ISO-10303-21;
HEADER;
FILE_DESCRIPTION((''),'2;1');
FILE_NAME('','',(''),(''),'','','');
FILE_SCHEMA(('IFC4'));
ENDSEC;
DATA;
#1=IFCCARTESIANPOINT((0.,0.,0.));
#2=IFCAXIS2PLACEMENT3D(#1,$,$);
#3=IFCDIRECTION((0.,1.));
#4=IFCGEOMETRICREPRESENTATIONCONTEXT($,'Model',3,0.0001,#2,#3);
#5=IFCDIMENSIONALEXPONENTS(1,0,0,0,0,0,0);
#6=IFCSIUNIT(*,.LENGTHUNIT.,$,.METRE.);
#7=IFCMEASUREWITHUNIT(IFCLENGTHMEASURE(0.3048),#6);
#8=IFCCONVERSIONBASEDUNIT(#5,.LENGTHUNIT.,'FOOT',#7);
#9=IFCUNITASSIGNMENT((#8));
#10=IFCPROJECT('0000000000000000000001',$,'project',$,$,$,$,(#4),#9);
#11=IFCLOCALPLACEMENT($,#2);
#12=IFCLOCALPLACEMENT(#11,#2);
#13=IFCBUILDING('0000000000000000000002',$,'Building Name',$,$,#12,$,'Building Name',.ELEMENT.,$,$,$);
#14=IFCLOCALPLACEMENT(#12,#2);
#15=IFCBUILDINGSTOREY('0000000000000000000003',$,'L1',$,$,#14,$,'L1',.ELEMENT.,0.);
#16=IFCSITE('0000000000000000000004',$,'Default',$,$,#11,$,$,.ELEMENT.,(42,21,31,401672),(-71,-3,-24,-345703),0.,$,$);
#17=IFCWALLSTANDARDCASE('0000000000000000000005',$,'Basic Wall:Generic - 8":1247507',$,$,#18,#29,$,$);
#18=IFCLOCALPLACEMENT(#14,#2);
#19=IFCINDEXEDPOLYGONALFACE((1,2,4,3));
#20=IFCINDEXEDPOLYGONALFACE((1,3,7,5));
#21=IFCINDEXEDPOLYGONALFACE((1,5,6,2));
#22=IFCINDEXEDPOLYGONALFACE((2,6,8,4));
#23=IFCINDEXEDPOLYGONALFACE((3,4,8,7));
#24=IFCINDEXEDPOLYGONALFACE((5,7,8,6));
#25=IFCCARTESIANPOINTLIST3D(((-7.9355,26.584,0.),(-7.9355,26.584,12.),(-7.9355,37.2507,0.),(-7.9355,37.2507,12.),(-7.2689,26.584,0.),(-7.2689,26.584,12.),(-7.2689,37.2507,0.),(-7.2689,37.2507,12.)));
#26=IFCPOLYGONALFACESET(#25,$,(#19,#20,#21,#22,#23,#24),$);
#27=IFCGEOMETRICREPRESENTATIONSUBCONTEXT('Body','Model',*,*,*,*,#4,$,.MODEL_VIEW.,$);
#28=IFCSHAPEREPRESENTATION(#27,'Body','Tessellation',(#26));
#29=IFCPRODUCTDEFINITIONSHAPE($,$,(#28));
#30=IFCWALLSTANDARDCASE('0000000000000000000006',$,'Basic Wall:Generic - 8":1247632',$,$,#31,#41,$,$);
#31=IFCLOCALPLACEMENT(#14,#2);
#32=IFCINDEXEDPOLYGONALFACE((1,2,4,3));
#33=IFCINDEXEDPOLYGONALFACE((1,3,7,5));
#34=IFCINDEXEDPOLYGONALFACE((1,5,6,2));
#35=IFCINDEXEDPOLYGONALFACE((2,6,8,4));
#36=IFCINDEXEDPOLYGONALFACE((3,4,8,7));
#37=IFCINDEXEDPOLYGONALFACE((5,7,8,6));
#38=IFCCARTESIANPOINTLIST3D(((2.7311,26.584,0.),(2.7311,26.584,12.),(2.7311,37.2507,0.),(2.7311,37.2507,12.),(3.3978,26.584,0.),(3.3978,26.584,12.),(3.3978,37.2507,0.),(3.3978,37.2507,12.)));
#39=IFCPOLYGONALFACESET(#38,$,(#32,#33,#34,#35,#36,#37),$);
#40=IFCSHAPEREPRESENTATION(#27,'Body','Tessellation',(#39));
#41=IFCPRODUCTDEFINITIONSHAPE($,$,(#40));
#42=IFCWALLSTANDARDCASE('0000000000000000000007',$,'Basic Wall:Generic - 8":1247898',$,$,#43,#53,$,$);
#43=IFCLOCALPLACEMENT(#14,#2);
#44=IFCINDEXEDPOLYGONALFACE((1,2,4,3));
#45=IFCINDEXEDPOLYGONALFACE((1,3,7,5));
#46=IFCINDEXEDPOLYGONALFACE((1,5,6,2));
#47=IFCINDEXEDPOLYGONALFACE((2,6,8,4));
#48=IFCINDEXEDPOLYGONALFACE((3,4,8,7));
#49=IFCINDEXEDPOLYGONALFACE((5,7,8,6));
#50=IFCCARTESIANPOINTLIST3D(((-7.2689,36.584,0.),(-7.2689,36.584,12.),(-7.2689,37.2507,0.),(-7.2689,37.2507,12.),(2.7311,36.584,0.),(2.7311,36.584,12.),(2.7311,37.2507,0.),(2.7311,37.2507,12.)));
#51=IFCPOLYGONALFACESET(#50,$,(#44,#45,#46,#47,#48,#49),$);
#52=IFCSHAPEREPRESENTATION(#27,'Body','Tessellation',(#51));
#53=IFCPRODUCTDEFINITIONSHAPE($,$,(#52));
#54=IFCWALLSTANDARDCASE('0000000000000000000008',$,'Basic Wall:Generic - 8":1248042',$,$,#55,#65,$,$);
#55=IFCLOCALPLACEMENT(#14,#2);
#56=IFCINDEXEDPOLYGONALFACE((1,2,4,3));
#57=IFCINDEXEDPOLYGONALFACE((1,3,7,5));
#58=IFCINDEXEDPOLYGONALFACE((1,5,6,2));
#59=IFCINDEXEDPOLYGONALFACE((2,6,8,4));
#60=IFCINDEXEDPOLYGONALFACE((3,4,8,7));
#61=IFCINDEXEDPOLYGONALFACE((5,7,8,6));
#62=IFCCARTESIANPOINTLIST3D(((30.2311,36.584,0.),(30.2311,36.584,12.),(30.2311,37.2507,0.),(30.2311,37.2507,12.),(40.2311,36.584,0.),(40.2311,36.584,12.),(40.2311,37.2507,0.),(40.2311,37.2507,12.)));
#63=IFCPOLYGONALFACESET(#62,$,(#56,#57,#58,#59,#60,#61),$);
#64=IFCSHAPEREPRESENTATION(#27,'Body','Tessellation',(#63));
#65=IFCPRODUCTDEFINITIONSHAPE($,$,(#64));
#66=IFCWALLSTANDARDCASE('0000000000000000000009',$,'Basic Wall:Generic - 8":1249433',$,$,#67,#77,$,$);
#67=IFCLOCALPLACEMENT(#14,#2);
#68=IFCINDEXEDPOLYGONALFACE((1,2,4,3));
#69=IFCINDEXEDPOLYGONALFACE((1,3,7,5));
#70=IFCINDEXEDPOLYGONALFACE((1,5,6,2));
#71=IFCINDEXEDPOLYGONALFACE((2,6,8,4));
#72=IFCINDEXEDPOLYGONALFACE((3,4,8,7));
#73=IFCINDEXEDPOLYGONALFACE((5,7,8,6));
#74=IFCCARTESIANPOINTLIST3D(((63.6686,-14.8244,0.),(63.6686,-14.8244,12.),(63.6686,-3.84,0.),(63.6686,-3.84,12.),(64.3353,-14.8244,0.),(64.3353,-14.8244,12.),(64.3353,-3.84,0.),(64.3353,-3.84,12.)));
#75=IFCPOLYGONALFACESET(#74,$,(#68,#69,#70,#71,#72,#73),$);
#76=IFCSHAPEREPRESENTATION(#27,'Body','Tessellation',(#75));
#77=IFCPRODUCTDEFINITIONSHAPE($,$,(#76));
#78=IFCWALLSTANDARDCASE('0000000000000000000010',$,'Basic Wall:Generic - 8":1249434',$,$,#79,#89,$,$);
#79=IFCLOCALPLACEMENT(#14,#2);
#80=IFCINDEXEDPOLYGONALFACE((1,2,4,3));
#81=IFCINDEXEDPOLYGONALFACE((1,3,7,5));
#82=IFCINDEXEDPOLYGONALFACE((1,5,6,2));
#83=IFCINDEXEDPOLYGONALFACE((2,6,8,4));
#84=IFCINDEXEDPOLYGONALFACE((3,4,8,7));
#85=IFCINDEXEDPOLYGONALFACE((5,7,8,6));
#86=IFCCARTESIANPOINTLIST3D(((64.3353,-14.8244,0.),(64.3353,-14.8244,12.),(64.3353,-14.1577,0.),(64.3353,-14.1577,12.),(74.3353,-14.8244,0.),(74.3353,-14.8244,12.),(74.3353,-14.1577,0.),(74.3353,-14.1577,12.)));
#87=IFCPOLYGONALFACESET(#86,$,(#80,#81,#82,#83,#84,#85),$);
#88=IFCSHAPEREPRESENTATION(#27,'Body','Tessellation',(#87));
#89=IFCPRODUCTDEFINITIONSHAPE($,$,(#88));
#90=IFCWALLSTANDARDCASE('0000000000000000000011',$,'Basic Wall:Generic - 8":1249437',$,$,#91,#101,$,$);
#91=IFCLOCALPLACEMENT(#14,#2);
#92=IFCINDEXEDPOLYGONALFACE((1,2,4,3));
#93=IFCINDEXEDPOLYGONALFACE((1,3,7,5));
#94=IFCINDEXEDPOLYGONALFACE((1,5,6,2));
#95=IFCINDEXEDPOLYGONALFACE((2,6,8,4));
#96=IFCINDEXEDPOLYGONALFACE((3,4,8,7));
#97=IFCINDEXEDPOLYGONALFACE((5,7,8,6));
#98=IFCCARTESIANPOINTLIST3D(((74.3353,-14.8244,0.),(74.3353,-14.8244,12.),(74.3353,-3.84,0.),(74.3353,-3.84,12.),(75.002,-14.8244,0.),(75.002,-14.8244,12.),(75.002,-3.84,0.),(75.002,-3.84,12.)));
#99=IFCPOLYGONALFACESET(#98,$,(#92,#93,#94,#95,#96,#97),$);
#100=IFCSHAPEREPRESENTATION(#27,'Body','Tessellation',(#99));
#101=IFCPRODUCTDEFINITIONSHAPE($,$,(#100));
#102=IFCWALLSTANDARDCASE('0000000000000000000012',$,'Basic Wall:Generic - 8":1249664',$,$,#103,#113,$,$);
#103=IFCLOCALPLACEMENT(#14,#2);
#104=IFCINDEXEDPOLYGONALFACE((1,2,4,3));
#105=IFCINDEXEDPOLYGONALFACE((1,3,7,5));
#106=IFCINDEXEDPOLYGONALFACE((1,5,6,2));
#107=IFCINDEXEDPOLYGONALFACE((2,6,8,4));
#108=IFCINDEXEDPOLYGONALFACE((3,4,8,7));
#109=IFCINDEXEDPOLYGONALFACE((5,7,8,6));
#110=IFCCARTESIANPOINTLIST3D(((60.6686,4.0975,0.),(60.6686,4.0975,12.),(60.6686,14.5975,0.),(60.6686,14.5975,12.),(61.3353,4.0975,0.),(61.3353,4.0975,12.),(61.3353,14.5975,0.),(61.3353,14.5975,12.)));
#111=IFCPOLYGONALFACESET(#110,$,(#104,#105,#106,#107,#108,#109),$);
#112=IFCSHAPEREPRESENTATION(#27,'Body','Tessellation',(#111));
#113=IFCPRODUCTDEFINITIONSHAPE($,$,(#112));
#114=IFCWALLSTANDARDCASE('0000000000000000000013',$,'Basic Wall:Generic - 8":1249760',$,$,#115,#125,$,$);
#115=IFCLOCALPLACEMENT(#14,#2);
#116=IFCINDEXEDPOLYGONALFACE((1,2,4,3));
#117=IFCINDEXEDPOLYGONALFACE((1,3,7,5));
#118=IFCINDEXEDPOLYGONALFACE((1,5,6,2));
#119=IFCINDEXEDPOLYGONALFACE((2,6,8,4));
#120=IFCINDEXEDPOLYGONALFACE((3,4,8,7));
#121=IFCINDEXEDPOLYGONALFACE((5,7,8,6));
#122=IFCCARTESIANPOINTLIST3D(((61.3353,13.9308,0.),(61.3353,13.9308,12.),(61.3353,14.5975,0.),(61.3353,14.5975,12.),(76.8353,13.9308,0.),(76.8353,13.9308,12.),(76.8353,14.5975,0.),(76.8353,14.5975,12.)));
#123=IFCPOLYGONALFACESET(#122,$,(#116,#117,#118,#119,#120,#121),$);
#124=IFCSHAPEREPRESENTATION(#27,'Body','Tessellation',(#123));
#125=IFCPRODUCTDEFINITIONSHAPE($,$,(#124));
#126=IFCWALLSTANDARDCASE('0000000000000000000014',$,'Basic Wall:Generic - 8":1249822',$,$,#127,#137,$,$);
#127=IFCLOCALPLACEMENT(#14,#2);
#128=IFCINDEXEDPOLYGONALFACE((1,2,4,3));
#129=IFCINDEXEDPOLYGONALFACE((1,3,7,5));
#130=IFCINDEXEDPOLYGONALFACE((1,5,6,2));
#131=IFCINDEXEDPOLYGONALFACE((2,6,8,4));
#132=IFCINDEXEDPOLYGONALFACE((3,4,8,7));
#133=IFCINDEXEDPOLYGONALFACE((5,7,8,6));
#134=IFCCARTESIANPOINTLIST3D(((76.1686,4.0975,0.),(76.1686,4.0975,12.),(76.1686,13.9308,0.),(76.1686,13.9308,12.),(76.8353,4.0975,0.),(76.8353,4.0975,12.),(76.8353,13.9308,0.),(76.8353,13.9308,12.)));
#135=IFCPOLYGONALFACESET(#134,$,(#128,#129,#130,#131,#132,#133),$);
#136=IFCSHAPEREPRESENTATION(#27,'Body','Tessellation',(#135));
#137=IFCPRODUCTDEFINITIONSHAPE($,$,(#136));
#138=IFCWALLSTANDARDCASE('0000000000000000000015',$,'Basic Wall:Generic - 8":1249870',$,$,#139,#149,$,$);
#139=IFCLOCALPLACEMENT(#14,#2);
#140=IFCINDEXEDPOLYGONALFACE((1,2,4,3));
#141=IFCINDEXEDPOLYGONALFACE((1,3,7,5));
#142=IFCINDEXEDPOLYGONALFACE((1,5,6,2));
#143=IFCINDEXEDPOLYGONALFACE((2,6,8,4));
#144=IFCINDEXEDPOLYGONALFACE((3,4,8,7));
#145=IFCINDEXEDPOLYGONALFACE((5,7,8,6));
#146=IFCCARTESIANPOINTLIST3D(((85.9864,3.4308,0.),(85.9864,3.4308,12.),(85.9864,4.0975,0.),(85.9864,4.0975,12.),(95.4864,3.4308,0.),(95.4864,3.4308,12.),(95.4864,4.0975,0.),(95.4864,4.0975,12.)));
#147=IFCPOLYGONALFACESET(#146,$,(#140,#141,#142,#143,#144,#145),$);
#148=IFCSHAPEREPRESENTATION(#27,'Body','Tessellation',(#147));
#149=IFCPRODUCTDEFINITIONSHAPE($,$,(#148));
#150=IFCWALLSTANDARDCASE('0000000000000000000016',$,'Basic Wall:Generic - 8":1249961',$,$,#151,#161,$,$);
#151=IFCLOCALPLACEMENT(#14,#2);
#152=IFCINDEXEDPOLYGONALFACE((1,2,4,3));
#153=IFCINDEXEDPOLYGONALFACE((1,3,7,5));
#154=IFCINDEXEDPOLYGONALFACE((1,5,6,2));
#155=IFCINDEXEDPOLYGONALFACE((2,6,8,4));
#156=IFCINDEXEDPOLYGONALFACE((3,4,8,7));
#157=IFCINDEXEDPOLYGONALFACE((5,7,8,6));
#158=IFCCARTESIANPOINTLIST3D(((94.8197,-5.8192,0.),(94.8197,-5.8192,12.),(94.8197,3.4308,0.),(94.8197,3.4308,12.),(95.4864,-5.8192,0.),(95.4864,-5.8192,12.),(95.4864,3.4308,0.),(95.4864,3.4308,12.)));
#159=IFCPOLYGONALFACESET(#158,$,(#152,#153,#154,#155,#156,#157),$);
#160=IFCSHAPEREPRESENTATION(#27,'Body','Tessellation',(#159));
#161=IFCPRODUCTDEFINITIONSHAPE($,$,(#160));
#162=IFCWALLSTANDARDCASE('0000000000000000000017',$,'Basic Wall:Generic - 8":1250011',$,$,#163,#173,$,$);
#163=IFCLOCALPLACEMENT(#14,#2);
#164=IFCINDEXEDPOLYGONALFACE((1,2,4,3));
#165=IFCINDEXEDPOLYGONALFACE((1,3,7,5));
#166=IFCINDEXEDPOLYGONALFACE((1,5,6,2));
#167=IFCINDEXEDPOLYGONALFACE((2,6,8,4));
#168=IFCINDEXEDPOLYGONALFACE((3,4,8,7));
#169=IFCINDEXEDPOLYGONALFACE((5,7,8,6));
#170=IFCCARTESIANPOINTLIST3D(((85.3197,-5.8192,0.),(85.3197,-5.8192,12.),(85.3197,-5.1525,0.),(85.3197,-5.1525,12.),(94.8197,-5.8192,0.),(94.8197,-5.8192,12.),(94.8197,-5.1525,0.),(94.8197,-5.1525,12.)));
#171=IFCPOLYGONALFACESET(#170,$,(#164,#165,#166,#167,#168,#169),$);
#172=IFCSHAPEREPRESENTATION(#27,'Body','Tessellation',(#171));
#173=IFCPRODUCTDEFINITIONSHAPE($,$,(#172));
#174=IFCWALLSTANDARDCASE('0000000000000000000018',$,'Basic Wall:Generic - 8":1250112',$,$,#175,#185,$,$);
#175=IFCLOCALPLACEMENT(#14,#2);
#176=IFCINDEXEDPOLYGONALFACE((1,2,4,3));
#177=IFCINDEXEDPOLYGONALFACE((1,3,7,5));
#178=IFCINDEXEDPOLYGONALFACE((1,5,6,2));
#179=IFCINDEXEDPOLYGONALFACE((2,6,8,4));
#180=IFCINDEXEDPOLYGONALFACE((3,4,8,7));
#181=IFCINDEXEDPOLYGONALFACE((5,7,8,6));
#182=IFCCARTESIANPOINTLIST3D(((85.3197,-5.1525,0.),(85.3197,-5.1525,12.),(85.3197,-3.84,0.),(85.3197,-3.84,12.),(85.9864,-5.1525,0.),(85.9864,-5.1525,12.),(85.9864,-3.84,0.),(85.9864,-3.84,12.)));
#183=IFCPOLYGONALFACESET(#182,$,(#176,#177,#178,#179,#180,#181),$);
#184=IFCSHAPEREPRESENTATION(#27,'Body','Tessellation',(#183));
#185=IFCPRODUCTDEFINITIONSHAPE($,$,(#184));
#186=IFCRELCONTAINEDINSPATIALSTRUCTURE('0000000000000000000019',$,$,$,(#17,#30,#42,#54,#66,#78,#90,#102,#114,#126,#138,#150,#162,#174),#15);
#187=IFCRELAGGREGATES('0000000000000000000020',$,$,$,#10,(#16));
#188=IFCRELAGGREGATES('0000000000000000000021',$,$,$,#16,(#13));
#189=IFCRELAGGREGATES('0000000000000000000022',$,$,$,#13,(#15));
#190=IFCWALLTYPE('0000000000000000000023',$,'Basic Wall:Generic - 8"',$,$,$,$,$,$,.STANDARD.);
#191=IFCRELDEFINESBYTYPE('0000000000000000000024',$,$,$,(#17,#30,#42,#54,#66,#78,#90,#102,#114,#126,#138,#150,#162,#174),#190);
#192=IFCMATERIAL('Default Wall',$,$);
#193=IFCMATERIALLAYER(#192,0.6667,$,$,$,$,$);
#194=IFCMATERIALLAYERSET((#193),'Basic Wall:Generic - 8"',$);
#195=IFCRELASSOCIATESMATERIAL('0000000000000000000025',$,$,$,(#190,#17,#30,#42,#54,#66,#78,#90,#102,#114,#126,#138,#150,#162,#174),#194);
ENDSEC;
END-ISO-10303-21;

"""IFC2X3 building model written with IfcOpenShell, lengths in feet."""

from ifc_helpers import new_model, entity, si_unit, converted_unit, direction, frame, frame_2d, origin, place, context, subcontext, project, spatial, rectangle, extrude, material, layer, layer_set, layer_usage, type_object, element, save


model = new_model("IFC2X3")

# Units and contexts
model_context = context("Model", 3, precision=0.0001, world=origin(), true_north=direction((0.0, 1.0)))
body_context = subcontext(model_context, "Body", "Model", "MODEL_VIEW")
ifc_project = project(units=[converted_unit("LENGTHUNIT", "FOOT", entity("IfcLengthMeasure", 0.3048), si_unit("LENGTHUNIT", "METRE"), dimensions=[1, 0, 0, 0, 0, 0, 0])], contexts=[model_context])

# Site, building, storey
site_placement = place(None, origin())
site = spatial("IfcSite", under=ifc_project, at=site_placement, Name="Default", CompositionType="ELEMENT", RefLatitude=(42, 21, 31, 401672), RefLongitude=(-71, -3, -24, -345703), RefElevation=0.0)
building_placement = place(site_placement, origin())
building = spatial("IfcBuilding", under=site, at=building_placement, Name="Building Name", LongName="Building Name", CompositionType="ELEMENT")
storey_placement = place(building_placement, origin())
storey = spatial("IfcBuildingStorey", under=building, at=storey_placement, Name="L1", LongName="L1", CompositionType="ELEMENT", Elevation=0.0)

# Walls
ifc_material_1 = material(Name="Default Wall")
ifc_layer_1 = layer(ifc_material_1, 0.6667)
ifc_layer_set_1 = layer_set([ifc_layer_1], Name="Basic Wall:Generic - 8\"")
wall_type_1 = type_object("IfcWallType", Name="Basic Wall:Generic - 8\"", PredefinedType="STANDARD", material=ifc_layer_set_1)
ifc_layer_usage_1 = layer_usage(ifc_layer_set_1, "AXIS2", "POSITIVE", -0.3333)
wall_1_placement = place(storey_placement, frame((-7.6022, 37.2507, 0.0), z_axis=(0.0, 0.0, 1.0), x_axis=(0.0, -1.0, 0.0)))
element("IfcWallStandardCase", 1, at=wall_1_placement, inside=storey, type_object=wall_type_1, material=ifc_layer_usage_1, Name="Basic Wall:Generic - 8\":1247507", context=body_context, shape_type="SweptSolid", body=[
    extrude(rectangle(XDim=10.6667, YDim=0.6667, at=frame_2d((5.3333, 0.0), x_axis=(-1.0, 0.0))), origin(), (0.0, 0.0, 1.0), 12.0),
])
ifc_layer_usage_2 = layer_usage(ifc_layer_set_1, "AXIS2", "NEGATIVE", 0.3333)
wall_2_placement = place(storey_placement, frame((3.0645, 37.2507, 0.0), z_axis=(0.0, 0.0, 1.0), x_axis=(0.0, -1.0, 0.0)))
element("IfcWallStandardCase", 2, at=wall_2_placement, inside=storey, type_object=wall_type_1, material=ifc_layer_usage_2, Name="Basic Wall:Generic - 8\":1247632", context=body_context, shape_type="SweptSolid", body=[
    extrude(rectangle(XDim=10.6667, YDim=0.6667, at=frame_2d((5.3333, 0.0), x_axis=(-1.0, 0.0))), origin(), (0.0, 0.0, 1.0), 12.0),
])
ifc_layer_usage_3 = layer_usage(ifc_layer_set_1, "AXIS2", "NEGATIVE", 0.3333)
wall_3_placement = place(storey_placement, frame((-7.2689, 36.9174, 0.0)))
element("IfcWallStandardCase", 3, at=wall_3_placement, inside=storey, type_object=wall_type_1, material=ifc_layer_usage_3, Name="Basic Wall:Generic - 8\":1247898", context=body_context, shape_type="SweptSolid", body=[
    extrude(rectangle(XDim=10.0, YDim=0.6667, at=frame_2d((5.0, 0.0), x_axis=(-1.0, 0.0))), origin(), (0.0, 0.0, 1.0), 12.0),
])
ifc_layer_usage_4 = layer_usage(ifc_layer_set_1, "AXIS2", "NEGATIVE", 0.3333)
wall_4_placement = place(storey_placement, frame((30.2311, 36.9174, 0.0)))
element("IfcWallStandardCase", 4, at=wall_4_placement, inside=storey, type_object=wall_type_1, material=ifc_layer_usage_4, Name="Basic Wall:Generic - 8\":1248042", context=body_context, shape_type="SweptSolid", body=[
    extrude(rectangle(XDim=10.0, YDim=0.6667, at=frame_2d((5.0, 0.0), x_axis=(-1.0, 0.0))), origin(), (0.0, 0.0, 1.0), 12.0),
])
ifc_layer_usage_5 = layer_usage(ifc_layer_set_1, "AXIS2", "POSITIVE", -0.3333)
wall_5_placement = place(storey_placement, frame((64.002, -3.84, 0.0), z_axis=(0.0, 0.0, 1.0), x_axis=(0.0, -1.0, 0.0)))
element("IfcWallStandardCase", 5, at=wall_5_placement, inside=storey, type_object=wall_type_1, material=ifc_layer_usage_5, Name="Basic Wall:Generic - 8\":1249433", context=body_context, shape_type="SweptSolid", body=[
    extrude(rectangle(XDim=10.9844, YDim=0.6667, at=frame_2d((5.4922, 0.0), x_axis=(-1.0, 0.0))), origin(), (0.0, 0.0, 1.0), 12.0),
])
ifc_layer_usage_6 = layer_usage(ifc_layer_set_1, "AXIS2", "POSITIVE", -0.3333)
wall_6_placement = place(storey_placement, frame((64.3353, -14.4911, 0.0)))
element("IfcWallStandardCase", 6, at=wall_6_placement, inside=storey, type_object=wall_type_1, material=ifc_layer_usage_6, Name="Basic Wall:Generic - 8\":1249434", context=body_context, shape_type="SweptSolid", body=[
    extrude(rectangle(XDim=10.0, YDim=0.6667, at=frame_2d((5.0, 0.0), x_axis=(-1.0, 0.0))), origin(), (0.0, 0.0, 1.0), 12.0),
])
ifc_layer_usage_7 = layer_usage(ifc_layer_set_1, "AXIS2", "NEGATIVE", 0.3333)
wall_7_placement = place(storey_placement, frame((74.6686, -3.84, 0.0), z_axis=(0.0, 0.0, 1.0), x_axis=(0.0, -1.0, 0.0)))
element("IfcWallStandardCase", 7, at=wall_7_placement, inside=storey, type_object=wall_type_1, material=ifc_layer_usage_7, Name="Basic Wall:Generic - 8\":1249437", context=body_context, shape_type="SweptSolid", body=[
    extrude(rectangle(XDim=10.9844, YDim=0.6667, at=frame_2d((5.4922, 0.0), x_axis=(-1.0, 0.0))), origin(), (0.0, 0.0, 1.0), 12.0),
])
ifc_layer_usage_8 = layer_usage(ifc_layer_set_1, "AXIS2", "NEGATIVE", 0.3333)
wall_8_placement = place(storey_placement, frame((61.002, 4.0975, 0.0), z_axis=(0.0, 0.0, 1.0), x_axis=(0.0, 1.0, 0.0)))
element("IfcWallStandardCase", 8, at=wall_8_placement, inside=storey, type_object=wall_type_1, material=ifc_layer_usage_8, Name="Basic Wall:Generic - 8\":1249664", context=body_context, shape_type="SweptSolid", body=[
    extrude(rectangle(XDim=10.5, YDim=0.6667, at=frame_2d((5.25, 0.0), x_axis=(-1.0, 0.0))), origin(), (0.0, 0.0, 1.0), 12.0),
])
ifc_layer_usage_9 = layer_usage(ifc_layer_set_1, "AXIS2", "NEGATIVE", 0.3333)
wall_9_placement = place(storey_placement, frame((61.3353, 14.2641, 0.0)))
element("IfcWallStandardCase", 9, at=wall_9_placement, inside=storey, type_object=wall_type_1, material=ifc_layer_usage_9, Name="Basic Wall:Generic - 8\":1249760", context=body_context, shape_type="SweptSolid", body=[
    extrude(rectangle(XDim=15.5, YDim=0.6667, at=frame_2d((7.75, 0.0), x_axis=(-1.0, 0.0))), origin(), (0.0, 0.0, 1.0), 12.0),
])
ifc_layer_usage_10 = layer_usage(ifc_layer_set_1, "AXIS2", "NEGATIVE", 0.3333)
wall_10_placement = place(storey_placement, frame((76.502, 13.9308, 0.0), z_axis=(0.0, 0.0, 1.0), x_axis=(0.0, -1.0, 0.0)))
element("IfcWallStandardCase", 10, at=wall_10_placement, inside=storey, type_object=wall_type_1, material=ifc_layer_usage_10, Name="Basic Wall:Generic - 8\":1249822", context=body_context, shape_type="SweptSolid", body=[
    extrude(rectangle(XDim=9.8333, YDim=0.6667, at=frame_2d((4.9167, 0.0), x_axis=(-1.0, 0.0))), origin(), (0.0, 0.0, 1.0), 12.0),
])
ifc_layer_usage_11 = layer_usage(ifc_layer_set_1, "AXIS2", "NEGATIVE", 0.3333)
wall_11_placement = place(storey_placement, frame((85.9864, 3.7641, 0.0)))
element("IfcWallStandardCase", 11, at=wall_11_placement, inside=storey, type_object=wall_type_1, material=ifc_layer_usage_11, Name="Basic Wall:Generic - 8\":1249870", context=body_context, shape_type="SweptSolid", body=[
    extrude(rectangle(XDim=9.5, YDim=0.6667, at=frame_2d((4.75, 0.0), x_axis=(-1.0, 0.0))), origin(), (0.0, 0.0, 1.0), 12.0),
])
ifc_layer_usage_12 = layer_usage(ifc_layer_set_1, "AXIS2", "NEGATIVE", 0.3333)
wall_12_placement = place(storey_placement, frame((95.153, 3.4308, 0.0), z_axis=(0.0, 0.0, 1.0), x_axis=(0.0, -1.0, 0.0)))
element("IfcWallStandardCase", 12, at=wall_12_placement, inside=storey, type_object=wall_type_1, material=ifc_layer_usage_12, Name="Basic Wall:Generic - 8\":1249961", context=body_context, shape_type="SweptSolid", body=[
    extrude(rectangle(XDim=9.25, YDim=0.6667, at=frame_2d((4.625, 0.0), x_axis=(-1.0, 0.0))), origin(), (0.0, 0.0, 1.0), 12.0),
])
ifc_layer_usage_13 = layer_usage(ifc_layer_set_1, "AXIS2", "NEGATIVE", 0.3333)
wall_13_placement = place(storey_placement, frame((94.8197, -5.4859, 0.0), z_axis=(0.0, 0.0, 1.0), x_axis=(-1.0, 0.0, 0.0)))
element("IfcWallStandardCase", 13, at=wall_13_placement, inside=storey, type_object=wall_type_1, material=ifc_layer_usage_13, Name="Basic Wall:Generic - 8\":1250011", context=body_context, shape_type="SweptSolid", body=[
    extrude(rectangle(XDim=9.5, YDim=0.6667, at=frame_2d((4.75, 0.0), x_axis=(-1.0, 0.0))), origin(), (0.0, 0.0, 1.0), 12.0),
])
ifc_layer_usage_14 = layer_usage(ifc_layer_set_1, "AXIS2", "NEGATIVE", 0.3333)
wall_14_placement = place(storey_placement, frame((85.653, -3.84, 0.0), z_axis=(0.0, 0.0, 1.0), x_axis=(0.0, -1.0, 0.0)))
element("IfcWallStandardCase", 14, at=wall_14_placement, inside=storey, type_object=wall_type_1, material=ifc_layer_usage_14, Name="Basic Wall:Generic - 8\":1250112", context=body_context, shape_type="SweptSolid", body=[
    extrude(rectangle(XDim=1.3125, YDim=0.6667, at=frame_2d((0.6563, 0.0), x_axis=(-1.0, 0.0))), origin(), (0.0, 0.0, 1.0), 12.0),
])

save(model, "model.ifc")
